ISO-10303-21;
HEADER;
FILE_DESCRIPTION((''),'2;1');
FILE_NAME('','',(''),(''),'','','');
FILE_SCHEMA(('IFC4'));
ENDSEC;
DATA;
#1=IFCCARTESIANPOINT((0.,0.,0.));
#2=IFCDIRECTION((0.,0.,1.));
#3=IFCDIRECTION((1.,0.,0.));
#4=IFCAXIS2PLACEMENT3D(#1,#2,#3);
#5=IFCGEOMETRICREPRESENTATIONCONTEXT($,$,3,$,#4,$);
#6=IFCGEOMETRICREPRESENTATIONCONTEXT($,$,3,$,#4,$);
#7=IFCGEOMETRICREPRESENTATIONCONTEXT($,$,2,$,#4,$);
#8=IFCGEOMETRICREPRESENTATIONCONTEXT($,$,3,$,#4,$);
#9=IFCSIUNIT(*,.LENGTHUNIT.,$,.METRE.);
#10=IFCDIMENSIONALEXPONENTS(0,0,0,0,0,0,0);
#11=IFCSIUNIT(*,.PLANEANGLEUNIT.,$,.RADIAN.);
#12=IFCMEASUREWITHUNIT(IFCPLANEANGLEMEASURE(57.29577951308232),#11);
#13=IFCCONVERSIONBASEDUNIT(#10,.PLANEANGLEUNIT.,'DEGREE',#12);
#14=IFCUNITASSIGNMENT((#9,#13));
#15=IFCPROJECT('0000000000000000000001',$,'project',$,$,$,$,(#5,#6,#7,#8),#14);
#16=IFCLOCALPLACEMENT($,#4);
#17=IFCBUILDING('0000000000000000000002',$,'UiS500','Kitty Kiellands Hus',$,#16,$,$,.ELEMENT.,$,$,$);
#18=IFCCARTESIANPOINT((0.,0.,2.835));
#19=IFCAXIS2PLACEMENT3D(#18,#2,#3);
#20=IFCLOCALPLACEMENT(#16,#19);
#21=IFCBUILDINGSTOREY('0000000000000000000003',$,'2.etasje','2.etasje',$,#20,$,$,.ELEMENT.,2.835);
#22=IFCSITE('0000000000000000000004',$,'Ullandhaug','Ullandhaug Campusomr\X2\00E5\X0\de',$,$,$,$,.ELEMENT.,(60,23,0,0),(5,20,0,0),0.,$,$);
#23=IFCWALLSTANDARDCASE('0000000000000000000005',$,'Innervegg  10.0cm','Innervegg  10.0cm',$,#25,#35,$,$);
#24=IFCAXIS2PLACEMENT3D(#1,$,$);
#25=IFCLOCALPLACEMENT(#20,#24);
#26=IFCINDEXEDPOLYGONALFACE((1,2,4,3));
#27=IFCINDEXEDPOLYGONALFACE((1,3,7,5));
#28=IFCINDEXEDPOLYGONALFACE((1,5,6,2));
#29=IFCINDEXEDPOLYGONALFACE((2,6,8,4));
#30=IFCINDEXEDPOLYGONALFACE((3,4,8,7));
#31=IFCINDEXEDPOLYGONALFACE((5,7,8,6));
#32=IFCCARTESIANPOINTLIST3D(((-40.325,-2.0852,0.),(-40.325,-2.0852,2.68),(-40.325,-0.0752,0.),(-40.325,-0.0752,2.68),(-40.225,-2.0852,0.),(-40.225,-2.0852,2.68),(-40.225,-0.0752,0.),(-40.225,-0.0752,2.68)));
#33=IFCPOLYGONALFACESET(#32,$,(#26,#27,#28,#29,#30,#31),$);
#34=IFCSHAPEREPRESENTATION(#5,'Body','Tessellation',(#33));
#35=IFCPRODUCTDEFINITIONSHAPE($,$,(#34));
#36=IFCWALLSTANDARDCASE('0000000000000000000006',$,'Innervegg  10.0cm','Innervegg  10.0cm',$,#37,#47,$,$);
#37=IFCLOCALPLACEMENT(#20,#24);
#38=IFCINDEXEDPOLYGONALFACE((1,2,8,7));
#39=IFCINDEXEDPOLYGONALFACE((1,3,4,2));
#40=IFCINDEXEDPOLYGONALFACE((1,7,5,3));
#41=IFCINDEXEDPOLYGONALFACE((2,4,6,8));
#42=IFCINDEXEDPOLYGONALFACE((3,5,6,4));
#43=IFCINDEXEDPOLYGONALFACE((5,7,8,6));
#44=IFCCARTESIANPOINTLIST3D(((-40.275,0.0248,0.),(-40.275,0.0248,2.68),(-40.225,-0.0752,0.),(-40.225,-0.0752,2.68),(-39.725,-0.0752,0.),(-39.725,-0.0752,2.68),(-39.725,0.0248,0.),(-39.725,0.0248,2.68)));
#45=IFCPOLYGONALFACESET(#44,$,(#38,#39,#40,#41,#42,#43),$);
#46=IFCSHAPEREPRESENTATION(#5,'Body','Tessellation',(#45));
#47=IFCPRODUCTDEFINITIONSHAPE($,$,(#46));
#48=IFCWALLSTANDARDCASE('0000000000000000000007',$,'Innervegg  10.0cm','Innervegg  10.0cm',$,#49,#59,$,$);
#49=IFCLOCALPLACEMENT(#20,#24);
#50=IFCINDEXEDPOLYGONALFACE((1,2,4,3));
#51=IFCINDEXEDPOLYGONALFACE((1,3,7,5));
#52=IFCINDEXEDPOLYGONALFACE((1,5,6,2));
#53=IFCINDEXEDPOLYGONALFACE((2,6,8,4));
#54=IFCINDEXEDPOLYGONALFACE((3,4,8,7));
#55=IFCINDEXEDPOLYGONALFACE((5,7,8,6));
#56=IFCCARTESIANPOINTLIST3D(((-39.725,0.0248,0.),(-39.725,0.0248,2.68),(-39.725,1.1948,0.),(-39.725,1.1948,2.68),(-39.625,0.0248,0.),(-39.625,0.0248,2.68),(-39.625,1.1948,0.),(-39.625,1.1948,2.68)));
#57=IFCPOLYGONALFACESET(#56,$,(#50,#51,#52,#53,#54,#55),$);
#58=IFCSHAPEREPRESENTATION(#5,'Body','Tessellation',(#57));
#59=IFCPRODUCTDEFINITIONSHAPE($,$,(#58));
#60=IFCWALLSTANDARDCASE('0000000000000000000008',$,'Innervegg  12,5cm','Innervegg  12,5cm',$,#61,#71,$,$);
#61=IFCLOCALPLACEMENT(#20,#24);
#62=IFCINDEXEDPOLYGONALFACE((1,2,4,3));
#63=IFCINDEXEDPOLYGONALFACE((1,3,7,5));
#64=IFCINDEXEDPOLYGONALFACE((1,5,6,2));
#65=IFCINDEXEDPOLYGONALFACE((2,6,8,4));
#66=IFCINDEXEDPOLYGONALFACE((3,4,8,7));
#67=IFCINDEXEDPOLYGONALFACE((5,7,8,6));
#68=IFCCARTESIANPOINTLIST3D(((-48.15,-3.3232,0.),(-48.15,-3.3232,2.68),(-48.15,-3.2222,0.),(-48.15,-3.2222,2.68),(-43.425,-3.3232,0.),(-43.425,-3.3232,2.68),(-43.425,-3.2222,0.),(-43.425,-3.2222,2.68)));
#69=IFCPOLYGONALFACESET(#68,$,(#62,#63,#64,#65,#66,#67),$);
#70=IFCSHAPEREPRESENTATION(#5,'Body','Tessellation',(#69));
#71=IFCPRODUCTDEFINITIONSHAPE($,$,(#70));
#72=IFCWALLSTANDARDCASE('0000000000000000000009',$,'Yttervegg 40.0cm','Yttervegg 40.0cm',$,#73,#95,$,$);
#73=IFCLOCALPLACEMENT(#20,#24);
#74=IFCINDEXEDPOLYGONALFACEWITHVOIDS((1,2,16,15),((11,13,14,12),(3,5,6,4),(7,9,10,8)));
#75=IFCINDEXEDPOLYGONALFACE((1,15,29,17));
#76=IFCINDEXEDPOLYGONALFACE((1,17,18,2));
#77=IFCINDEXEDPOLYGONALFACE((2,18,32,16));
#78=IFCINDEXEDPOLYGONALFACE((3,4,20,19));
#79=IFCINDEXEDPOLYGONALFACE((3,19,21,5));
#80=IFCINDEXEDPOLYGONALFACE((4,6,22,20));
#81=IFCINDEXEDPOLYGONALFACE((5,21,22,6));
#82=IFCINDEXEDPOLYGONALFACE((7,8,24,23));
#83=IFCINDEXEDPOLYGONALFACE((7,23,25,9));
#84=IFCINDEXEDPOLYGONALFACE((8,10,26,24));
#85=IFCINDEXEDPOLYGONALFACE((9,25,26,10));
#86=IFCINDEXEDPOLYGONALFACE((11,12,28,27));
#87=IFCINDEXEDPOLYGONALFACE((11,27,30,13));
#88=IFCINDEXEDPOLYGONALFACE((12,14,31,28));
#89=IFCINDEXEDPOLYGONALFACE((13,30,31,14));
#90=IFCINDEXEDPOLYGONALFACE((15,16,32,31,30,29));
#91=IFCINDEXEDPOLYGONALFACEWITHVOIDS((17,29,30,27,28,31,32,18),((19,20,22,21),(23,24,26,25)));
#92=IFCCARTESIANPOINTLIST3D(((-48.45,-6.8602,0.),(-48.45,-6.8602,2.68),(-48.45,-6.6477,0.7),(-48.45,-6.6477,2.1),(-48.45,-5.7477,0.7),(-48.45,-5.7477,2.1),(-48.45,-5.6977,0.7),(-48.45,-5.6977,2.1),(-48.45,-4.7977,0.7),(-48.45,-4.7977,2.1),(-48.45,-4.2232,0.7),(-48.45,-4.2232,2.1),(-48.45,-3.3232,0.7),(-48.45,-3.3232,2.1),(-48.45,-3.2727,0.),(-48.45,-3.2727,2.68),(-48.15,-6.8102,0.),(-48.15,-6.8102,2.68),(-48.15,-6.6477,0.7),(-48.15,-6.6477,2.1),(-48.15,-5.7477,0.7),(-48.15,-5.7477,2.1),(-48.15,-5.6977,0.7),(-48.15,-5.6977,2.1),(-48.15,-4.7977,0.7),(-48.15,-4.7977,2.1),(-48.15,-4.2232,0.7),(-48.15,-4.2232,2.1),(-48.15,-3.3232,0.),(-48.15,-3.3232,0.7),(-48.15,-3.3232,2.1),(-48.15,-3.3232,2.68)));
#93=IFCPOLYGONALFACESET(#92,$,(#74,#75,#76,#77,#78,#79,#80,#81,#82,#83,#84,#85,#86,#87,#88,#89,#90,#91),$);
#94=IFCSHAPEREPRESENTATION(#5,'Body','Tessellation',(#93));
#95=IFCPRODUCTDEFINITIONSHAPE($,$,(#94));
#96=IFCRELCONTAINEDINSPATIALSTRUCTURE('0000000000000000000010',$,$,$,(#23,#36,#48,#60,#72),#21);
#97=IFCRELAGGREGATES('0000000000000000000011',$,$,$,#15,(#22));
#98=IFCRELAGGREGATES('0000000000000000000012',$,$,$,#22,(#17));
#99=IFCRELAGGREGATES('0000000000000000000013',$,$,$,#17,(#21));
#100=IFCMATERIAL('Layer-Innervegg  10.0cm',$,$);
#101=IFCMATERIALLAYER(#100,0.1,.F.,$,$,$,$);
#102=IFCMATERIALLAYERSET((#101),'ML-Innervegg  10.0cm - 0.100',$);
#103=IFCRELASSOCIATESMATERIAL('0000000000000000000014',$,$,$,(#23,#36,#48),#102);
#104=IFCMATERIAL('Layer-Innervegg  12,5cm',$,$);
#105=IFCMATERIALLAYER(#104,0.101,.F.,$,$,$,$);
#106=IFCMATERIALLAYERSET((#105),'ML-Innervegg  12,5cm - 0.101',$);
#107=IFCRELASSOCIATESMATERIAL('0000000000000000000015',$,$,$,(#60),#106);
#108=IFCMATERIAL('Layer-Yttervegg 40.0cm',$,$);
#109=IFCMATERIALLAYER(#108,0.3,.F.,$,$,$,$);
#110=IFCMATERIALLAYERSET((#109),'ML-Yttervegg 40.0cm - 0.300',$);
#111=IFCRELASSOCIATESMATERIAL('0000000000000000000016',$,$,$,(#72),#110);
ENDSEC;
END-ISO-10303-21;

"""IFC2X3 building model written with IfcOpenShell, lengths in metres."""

from ifc_helpers import new_model, entity, si_unit, converted_unit, frame, origin_with_axes, place, context, project, spatial, polyline, outline, extrude, material, layer, layer_set, layer_usage, element, save


model = new_model("IFC2X3")

# Units and contexts
context_of_model_1 = context(None, 3, world=origin_with_axes())
context_of_model_2 = context(None, 3, world=origin_with_axes())
context_of_model_3 = context(None, 2, world=origin_with_axes())
context_of_model_4 = context(None, 3, world=origin_with_axes())
ifc_project = project(units=[si_unit("LENGTHUNIT", "METRE"), converted_unit("PLANEANGLEUNIT", "DEGREE", entity("IfcPlaneAngleMeasure", 57.29577951308232), si_unit("PLANEANGLEUNIT", "RADIAN"), dimensions=[0, 0, 0, 0, 0, 0, 0])], contexts=[context_of_model_1, context_of_model_2, context_of_model_3, context_of_model_4])

# Site, building, storey
site = spatial("IfcSite", under=ifc_project, Name="Ullandhaug", Description="Ullandhaug Campusområde", CompositionType="ELEMENT", RefLatitude=(60, 23, 0, 0), RefLongitude=(5, 20, 0, 0), RefElevation=0.0)
building_placement = place(None, origin_with_axes())
building = spatial("IfcBuilding", under=site, at=building_placement, Name="UiS500", Description="Kitty Kiellands Hus", CompositionType="ELEMENT")
storey_placement = place(building_placement, frame((0.0, 0.0, 2.835), z_axis=(0.0, 0.0, 1.0), x_axis=(1.0, 0.0, 0.0)))
storey = spatial("IfcBuildingStorey", under=building, at=storey_placement, Name="2.etasje", Description="2.etasje", CompositionType="ELEMENT", Elevation=2.835)

# Shared definitions
ifc_material_1 = material(Name="Layer-Innervegg  10.0cm")
ifc_layer_1 = layer(ifc_material_1, 0.1, ventilated=False)
ifc_layer_set_1 = layer_set([ifc_layer_1], Name="ML-Innervegg  10.0cm - 0.100")
ifc_layer_usage_1 = layer_usage(ifc_layer_set_1, "AXIS2", "POSITIVE", 0.0)

# Walls
wall_1_placement = place(storey_placement, frame((-40.225, -2.0852, 0.0), z_axis=(0.0, 0.0, 1.0), x_axis=(0.0, 1.0, 0.0)))
element("IfcWallStandardCase", 1, at=wall_1_placement, inside=storey, material=ifc_layer_usage_1, Name="Innervegg  10.0cm", Description="Innervegg  10.0cm", context=context_of_model_1, shape_type="SweptSolid", body=[
    extrude(outline(polyline([(0.0, 0.0), (2.01, 0.0), (2.01, 0.1), (0.0, 0.1), (0.0, 0.0)])), frame((0.0, 0.0, 0.0), z_axis=(0.0, 0.0, 1.0), x_axis=(1.0, 0.0, 0.0)), (0.0, 0.0, 1.0), 2.68),
])
wall_2_placement = place(storey_placement, frame((-40.225, -0.0752, 0.0), z_axis=(0.0, 0.0, 1.0), x_axis=(1.0, 0.0, 0.0)))
element("IfcWallStandardCase", 2, at=wall_2_placement, inside=storey, material=ifc_layer_usage_1, Name="Innervegg  10.0cm", Description="Innervegg  10.0cm", context=context_of_model_1, shape_type="SweptSolid", body=[
    extrude(outline(polyline([(0.0, 0.0), (0.5, 0.0), (0.5, 0.1), (-0.05, 0.1), (0.0, 0.0)])), origin_with_axes(), (0.0, 0.0, 1.0), 2.68),
])
wall_3_placement = place(storey_placement, frame((-39.625, 0.0248, 0.0), z_axis=(0.0, 0.0, 1.0), x_axis=(0.0, 1.0, 0.0)))
element("IfcWallStandardCase", 3, at=wall_3_placement, inside=storey, material=ifc_layer_usage_1, Name="Innervegg  10.0cm", Description="Innervegg  10.0cm", context=context_of_model_1, shape_type="SweptSolid", body=[
    extrude(outline(polyline([(0.0, 0.0), (1.17, 0.0), (1.17, 0.1), (0.0, 0.1), (0.0, 0.0)])), frame((0.0, 0.0, 0.0), z_axis=(0.0, 0.0, 1.0), x_axis=(1.0, 0.0, 0.0)), (0.0, 0.0, 1.0), 2.68),
])
ifc_material_2 = material(Name="Layer-Innervegg  12,5cm")
ifc_layer_2 = layer(ifc_material_2, 0.101, ventilated=False)
ifc_layer_set_2 = layer_set([ifc_layer_2], Name="ML-Innervegg  12,5cm - 0.101")
ifc_layer_usage_2 = layer_usage(ifc_layer_set_2, "AXIS2", "POSITIVE", 0.0)
wall_4_placement = place(storey_placement, frame((-48.15, -3.3232, 0.0), z_axis=(0.0, 0.0, 1.0), x_axis=(1.0, 0.0, 0.0)))
element("IfcWallStandardCase", 4, at=wall_4_placement, inside=storey, material=ifc_layer_usage_2, Name="Innervegg  12,5cm", Description="Innervegg  12,5cm", context=context_of_model_1, shape_type="SweptSolid", body=[
    extrude(outline(polyline([(0.0, 0.0), (4.725, 0.0), (4.725, 0.101), (0.0, 0.101), (0.0, 0.0)])), origin_with_axes(), (0.0, 0.0, 1.0), 2.68),
])

# Wall, openings
ifc_material_3 = material(Name="Layer-Yttervegg 40.0cm")
ifc_layer_3 = layer(ifc_material_3, 0.3, ventilated=False)
ifc_layer_set_3 = layer_set([ifc_layer_3], Name="ML-Yttervegg 40.0cm - 0.300")
ifc_layer_usage_3 = layer_usage(ifc_layer_set_3, "AXIS2", "POSITIVE", 0.0)
wall_5_placement = place(storey_placement, frame((-48.45, -3.2727, 0.0), z_axis=(0.0, 0.0, 1.0), x_axis=(0.0, -1.0, 0.0)))
wall_5 = element("IfcWallStandardCase", 5, at=wall_5_placement, inside=storey, material=ifc_layer_usage_3, Name="Yttervegg 40.0cm", Description="Yttervegg 40.0cm", context=context_of_model_1, shape_type="SweptSolid", body=[
    extrude(outline(polyline([(0.0, 0.0), (3.5875, 0.0), (3.5375, 0.3), (0.0505, 0.3), (0.0, 0.0)])), frame((0.0, 0.0, 0.0), z_axis=(0.0, 0.0, 1.0), x_axis=(1.0, 0.0, 0.0)), (0.0, 0.0, 1.0), 2.68),
])
opening_1_placement = place(wall_5_placement, frame((2.475, 0.3, 0.7), z_axis=(0.0, 0.0, 1.0), x_axis=(1.0, 0.0, 0.0)))
element("IfcOpeningElement", 6, at=opening_1_placement, cuts=wall_5, context=context_of_model_1, shape_type="SweptSolid", body=[
    extrude(outline(polyline([(0.0, 0.0), (1.4, 0.0), (1.4, 0.9), (0.0, 0.9), (0.0, 0.0)])), frame((0.0, 0.0, 0.0), z_axis=(0.0, 1.0, 0.0), x_axis=(0.0, 0.0, 1.0)), (0.0, 0.0, -1.0), 0.3),
])
opening_2_placement = place(wall_5_placement, frame((1.525, 0.3, 0.7), z_axis=(0.0, 0.0, 1.0), x_axis=(1.0, 0.0, 0.0)))
element("IfcOpeningElement", 7, at=opening_2_placement, cuts=wall_5, context=context_of_model_1, shape_type="SweptSolid", body=[
    extrude(outline(polyline([(0.0, 0.0), (1.4, 0.0), (1.4, 0.9), (0.0, 0.9), (0.0, 0.0)])), frame((0.0, 0.0, 0.0), z_axis=(0.0, 1.0, 0.0), x_axis=(0.0, 0.0, 1.0)), (0.0, 0.0, -1.0), 0.3),
])
opening_3_placement = place(wall_5_placement, frame((0.0505, 0.3, 0.7), z_axis=(0.0, 0.0, 1.0), x_axis=(1.0, 0.0, 0.0)))
element("IfcOpeningElement", 8, at=opening_3_placement, cuts=wall_5, context=context_of_model_1, shape_type="SweptSolid", body=[
    extrude(outline(polyline([(0.0, 0.0), (1.4, 0.0), (1.4, 0.9), (0.0, 0.9), (0.0, 0.0)])), frame((0.0, 0.0, 0.0), z_axis=(0.0, 1.0, 0.0), x_axis=(0.0, 0.0, 1.0)), (0.0, 0.0, -1.0), 0.3),
])

save(model, "model.ifc")
